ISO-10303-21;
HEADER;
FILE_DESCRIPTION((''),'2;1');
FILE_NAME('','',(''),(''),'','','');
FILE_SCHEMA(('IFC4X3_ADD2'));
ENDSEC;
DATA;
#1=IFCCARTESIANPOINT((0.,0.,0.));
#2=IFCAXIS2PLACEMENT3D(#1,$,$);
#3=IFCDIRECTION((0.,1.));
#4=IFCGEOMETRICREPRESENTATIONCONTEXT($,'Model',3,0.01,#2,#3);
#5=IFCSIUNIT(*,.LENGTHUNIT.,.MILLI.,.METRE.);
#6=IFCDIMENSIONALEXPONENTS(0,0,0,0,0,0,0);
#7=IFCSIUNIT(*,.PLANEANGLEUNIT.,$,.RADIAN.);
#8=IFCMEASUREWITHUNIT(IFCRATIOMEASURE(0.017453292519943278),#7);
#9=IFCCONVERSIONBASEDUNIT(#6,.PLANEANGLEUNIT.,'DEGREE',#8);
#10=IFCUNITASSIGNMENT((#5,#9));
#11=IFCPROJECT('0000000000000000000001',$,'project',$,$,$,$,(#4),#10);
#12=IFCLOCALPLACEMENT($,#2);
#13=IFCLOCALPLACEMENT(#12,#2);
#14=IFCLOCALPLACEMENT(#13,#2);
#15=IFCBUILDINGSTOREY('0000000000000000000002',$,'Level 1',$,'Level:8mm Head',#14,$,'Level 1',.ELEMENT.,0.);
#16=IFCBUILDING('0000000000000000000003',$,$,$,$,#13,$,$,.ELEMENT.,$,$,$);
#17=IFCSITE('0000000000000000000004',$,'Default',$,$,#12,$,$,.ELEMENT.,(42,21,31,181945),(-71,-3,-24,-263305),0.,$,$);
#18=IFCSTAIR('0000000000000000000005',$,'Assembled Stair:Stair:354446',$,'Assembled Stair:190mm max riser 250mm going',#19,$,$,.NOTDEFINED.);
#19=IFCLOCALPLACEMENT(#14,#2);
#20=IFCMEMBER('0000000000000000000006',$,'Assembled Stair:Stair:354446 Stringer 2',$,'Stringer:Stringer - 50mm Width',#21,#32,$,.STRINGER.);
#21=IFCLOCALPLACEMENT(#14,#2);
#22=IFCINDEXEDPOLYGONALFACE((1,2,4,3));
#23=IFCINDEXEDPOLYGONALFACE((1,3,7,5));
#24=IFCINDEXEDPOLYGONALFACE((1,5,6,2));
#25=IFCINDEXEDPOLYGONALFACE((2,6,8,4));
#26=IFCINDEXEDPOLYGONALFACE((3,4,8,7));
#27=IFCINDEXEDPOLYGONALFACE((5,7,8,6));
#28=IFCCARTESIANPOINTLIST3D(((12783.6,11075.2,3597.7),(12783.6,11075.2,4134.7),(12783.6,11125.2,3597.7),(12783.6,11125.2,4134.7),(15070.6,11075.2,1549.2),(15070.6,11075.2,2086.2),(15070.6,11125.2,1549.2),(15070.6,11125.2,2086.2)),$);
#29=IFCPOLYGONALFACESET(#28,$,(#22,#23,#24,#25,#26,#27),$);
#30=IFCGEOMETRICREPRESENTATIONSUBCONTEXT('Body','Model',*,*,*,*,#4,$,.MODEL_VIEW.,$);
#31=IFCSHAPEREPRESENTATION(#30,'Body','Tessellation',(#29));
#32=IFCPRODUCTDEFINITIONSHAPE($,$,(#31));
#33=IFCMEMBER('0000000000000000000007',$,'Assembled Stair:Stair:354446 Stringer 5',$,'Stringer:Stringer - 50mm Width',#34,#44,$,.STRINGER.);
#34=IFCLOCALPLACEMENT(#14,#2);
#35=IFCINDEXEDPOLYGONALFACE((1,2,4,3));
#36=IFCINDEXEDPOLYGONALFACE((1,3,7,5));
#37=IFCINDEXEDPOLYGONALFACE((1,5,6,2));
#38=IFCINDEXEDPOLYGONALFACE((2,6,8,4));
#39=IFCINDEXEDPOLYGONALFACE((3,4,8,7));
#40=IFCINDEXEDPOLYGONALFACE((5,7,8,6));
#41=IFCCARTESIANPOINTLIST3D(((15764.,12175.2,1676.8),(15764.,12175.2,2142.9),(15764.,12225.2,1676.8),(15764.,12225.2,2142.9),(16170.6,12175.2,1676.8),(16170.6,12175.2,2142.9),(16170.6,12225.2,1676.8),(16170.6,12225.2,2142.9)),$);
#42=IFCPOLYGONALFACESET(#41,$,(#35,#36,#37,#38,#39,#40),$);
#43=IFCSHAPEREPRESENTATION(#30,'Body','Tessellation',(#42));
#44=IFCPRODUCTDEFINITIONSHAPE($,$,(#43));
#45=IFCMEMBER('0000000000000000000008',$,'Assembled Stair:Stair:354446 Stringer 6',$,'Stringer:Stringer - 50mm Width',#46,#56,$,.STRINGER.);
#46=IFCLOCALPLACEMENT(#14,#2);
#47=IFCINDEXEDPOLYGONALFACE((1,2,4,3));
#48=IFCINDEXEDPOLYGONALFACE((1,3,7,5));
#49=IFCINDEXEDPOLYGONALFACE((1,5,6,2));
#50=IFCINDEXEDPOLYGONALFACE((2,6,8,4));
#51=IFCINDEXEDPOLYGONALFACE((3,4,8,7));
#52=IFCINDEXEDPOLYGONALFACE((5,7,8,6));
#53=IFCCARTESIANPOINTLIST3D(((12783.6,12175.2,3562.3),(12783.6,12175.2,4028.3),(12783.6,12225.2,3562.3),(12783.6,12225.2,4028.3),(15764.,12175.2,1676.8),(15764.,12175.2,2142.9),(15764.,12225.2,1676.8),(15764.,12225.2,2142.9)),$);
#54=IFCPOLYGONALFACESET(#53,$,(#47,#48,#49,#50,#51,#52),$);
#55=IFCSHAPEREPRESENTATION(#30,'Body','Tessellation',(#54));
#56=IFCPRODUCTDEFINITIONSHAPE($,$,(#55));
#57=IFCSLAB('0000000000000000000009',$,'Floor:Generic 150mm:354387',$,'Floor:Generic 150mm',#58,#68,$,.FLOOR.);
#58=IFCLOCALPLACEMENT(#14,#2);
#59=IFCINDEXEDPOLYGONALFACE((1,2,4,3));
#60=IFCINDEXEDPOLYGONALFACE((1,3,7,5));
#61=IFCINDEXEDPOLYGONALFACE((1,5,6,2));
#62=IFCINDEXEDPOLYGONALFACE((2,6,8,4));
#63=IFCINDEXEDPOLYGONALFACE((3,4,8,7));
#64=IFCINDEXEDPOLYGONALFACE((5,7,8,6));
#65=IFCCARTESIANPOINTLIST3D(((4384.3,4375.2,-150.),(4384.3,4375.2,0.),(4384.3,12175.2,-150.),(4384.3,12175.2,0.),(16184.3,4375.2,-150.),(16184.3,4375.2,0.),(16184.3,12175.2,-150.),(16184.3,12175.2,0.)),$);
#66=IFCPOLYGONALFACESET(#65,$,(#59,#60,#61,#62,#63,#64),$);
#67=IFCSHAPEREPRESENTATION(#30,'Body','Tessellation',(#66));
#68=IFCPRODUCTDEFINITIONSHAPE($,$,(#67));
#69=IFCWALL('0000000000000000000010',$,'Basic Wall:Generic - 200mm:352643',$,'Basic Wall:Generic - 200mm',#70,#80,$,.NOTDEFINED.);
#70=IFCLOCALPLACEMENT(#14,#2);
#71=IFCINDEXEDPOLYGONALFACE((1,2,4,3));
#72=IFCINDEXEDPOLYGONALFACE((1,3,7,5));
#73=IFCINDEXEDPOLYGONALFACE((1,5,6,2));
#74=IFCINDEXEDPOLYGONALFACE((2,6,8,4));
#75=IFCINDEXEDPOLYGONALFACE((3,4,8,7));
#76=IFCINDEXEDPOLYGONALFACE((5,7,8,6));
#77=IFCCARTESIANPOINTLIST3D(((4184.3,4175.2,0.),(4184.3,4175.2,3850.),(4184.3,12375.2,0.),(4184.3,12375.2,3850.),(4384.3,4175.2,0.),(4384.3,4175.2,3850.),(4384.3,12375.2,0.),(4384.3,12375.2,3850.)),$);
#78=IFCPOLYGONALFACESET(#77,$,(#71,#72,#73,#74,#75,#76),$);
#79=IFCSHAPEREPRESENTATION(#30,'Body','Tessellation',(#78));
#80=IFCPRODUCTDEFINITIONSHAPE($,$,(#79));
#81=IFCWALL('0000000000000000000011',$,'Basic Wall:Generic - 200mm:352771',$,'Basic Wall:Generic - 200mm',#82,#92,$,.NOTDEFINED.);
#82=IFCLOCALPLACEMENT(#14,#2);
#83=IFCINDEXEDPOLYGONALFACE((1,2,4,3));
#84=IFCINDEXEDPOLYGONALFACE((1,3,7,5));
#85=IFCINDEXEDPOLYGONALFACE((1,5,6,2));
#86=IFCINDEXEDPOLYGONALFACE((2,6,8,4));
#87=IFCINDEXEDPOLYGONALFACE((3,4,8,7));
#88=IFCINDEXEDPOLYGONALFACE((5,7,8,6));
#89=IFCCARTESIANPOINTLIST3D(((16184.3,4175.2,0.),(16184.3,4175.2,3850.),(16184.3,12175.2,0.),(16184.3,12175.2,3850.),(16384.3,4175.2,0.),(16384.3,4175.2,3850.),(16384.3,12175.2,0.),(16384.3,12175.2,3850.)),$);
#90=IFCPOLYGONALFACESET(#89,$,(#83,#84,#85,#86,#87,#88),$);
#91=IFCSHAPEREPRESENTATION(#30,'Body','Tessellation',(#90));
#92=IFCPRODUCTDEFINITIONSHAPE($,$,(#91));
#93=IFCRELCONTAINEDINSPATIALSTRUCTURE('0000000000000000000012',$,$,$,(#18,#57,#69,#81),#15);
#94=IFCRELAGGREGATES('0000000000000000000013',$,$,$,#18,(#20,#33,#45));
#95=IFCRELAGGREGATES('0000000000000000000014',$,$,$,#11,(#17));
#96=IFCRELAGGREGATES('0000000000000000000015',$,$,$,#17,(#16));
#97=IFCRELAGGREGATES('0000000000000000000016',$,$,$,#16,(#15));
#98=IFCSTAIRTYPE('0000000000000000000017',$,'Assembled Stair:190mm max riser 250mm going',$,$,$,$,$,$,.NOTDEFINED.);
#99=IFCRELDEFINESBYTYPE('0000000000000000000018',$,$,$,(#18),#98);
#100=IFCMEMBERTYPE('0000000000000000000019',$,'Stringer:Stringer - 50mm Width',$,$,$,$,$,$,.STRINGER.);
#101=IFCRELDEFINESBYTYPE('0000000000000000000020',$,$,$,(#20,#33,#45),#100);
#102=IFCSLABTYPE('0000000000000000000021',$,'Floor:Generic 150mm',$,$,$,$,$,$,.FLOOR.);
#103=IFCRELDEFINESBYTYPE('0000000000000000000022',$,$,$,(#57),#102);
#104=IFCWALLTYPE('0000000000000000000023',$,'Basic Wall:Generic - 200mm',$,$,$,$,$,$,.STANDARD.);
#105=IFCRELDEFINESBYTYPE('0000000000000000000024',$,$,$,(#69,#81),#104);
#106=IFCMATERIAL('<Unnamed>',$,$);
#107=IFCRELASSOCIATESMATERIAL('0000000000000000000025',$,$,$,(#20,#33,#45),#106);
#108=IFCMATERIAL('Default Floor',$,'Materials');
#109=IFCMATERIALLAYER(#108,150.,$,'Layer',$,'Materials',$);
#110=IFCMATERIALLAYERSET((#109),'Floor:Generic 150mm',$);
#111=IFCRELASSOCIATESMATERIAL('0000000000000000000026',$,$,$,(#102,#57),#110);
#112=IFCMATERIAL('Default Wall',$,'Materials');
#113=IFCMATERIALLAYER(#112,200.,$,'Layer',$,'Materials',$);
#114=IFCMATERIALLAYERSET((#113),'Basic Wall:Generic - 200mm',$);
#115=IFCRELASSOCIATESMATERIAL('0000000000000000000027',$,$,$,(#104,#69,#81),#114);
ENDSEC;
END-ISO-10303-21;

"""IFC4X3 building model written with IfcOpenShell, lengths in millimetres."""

from ifc_helpers import new_model, entity, si_unit, converted_unit, direction, frame, frame_2d, origin, place, context, subcontext, project, spatial, polyline, rectangle, outline, extrude, clip, bounded_halfspace, material, layer, layer_set, layer_usage, type_object, element, aggregate, save


model = new_model("IFC4X3")

# Units and contexts
model_context = context("Model", 3, precision=0.01, world=origin(), true_north=direction((0.0, 1.0)))
body_context = subcontext(model_context, "Body", "Model", "MODEL_VIEW")
ifc_project = project(units=[si_unit("LENGTHUNIT", "METRE", prefix="MILLI"), converted_unit("PLANEANGLEUNIT", "DEGREE", entity("IfcRatioMeasure", 0.017453292519943278), si_unit("PLANEANGLEUNIT", "RADIAN"), dimensions=[0, 0, 0, 0, 0, 0, 0])], contexts=[model_context])

# Site, building, storey
site_placement = place(None, origin())
site = spatial("IfcSite", under=ifc_project, at=site_placement, Name="Default", CompositionType="ELEMENT", RefLatitude=(42, 21, 31, 181945), RefLongitude=(-71, -3, -24, -263305), RefElevation=0.0)
building_placement = place(site_placement, origin())
building = spatial("IfcBuilding", under=site, at=building_placement, CompositionType="ELEMENT")
storey_placement = place(building_placement, origin())
storey = spatial("IfcBuildingStorey", under=building, at=storey_placement, Name="Level 1", ObjectType="Level:8mm Head", LongName="Level 1", CompositionType="ELEMENT", Elevation=0.0)

# Stair, members
stair_type = type_object("IfcStairType", Name="Assembled Stair:190mm max riser 250mm going", PredefinedType="NOTDEFINED")
stair_placement = place(storey_placement, origin())
stair = element("IfcStair", 1, at=stair_placement, inside=storey, type_object=stair_type, Name="Assembled Stair:Stair:354446", ObjectType="Assembled Stair:190mm max riser 250mm going", PredefinedType="NOTDEFINED")
ifc_material_1 = material(Name="<Unnamed>")
member_type = type_object("IfcMemberType", Name="Stringer:Stringer - 50mm Width", PredefinedType="STRINGER")
member_1_placement = place(stair_placement, frame((12783.6, 11075.2, 1549.2)))
member_1 = element("IfcMember", 2, at=member_1_placement, type_object=member_type, material=ifc_material_1, Name="Assembled Stair:Stair:354446 Stringer 2", ObjectType="Stringer:Stringer - 50mm Width", PredefinedType="STRINGER", context=body_context, shape_type="SweptSolid", body=[
    extrude(outline(polyline([(-1714.3, -200.0), (1356.0, -200.0), (1714.3, 200.0), (-1356.0, 200.0), (-1714.3, -200.0)])), frame((1143.5, 0.0, 1292.8), z_axis=(0.0, 1.0, 0.0), x_axis=(-0.744871, 0.0, 0.667208)), (0.0, 0.0, 1.0), 50.0),
])
member_2_placement = place(stair_placement, frame((15764.0, 12175.2, 1676.8)))
member_2 = element("IfcMember", 3, at=member_2_placement, type_object=member_type, material=ifc_material_1, Name="Assembled Stair:Stair:354446 Stringer 5", ObjectType="Stringer:Stringer - 50mm Width", PredefinedType="STRINGER", context=body_context, shape_type="SweptSolid", body=[
    extrude(rectangle(XDim=406.6, YDim=50.0, at=frame_2d((0.0, 0.0), x_axis=(1.0, 0.0))), frame((203.3, 25.0, 0.0), z_axis=(0.0, 0.0, 1.0), x_axis=(-1.0, 0.0, 0.0)), (0.0, 0.0, 1.0), 466.1),
])
member_3_placement = place(stair_placement, frame((12783.6, 12175.2, 1676.8)))
member_3 = element("IfcMember", 4, at=member_3_placement, type_object=member_type, material=ifc_material_1, Name="Assembled Stair:Stair:354446 Stringer 6", ObjectType="Stringer:Stringer - 50mm Width", PredefinedType="STRINGER", context=body_context, shape_type="SweptSolid", body=[
    extrude(outline(polyline([(-1887.9, -196.9), (1638.7, -196.9), (1887.9, 196.9), (-1638.7, 196.9), (-1887.9, -196.9)])), frame((1490.2, 0.0, 1175.8), z_axis=(0.0, 1.0, 0.0), x_axis=(-0.845092, 0.0, 0.53462)), (0.0, 0.0, 1.0), 50.0),
])

# Slab
ifc_material_2 = material(Name="Default Floor", Category="Materials")
ifc_layer_1 = layer(ifc_material_2, 150.0, Name="Layer", Category="Materials")
ifc_layer_set_1 = layer_set([ifc_layer_1], Name="Floor:Generic 150mm")
ifc_layer_usage = layer_usage(ifc_layer_set_1, "AXIS3", "POSITIVE", 0.0)
slab_type = type_object("IfcSlabType", Name="Floor:Generic 150mm", PredefinedType="FLOOR", material=ifc_layer_set_1)
slab_placement = place(storey_placement, origin())
element("IfcSlab", 5, at=slab_placement, inside=storey, type_object=slab_type, material=ifc_layer_usage, Name="Floor:Generic 150mm:354387", ObjectType="Floor:Generic 150mm", PredefinedType="FLOOR", context=body_context, shape_type="SweptSolid", body=[
    extrude(rectangle(XDim=7800.0, YDim=11800.0, at=frame_2d((0.0, 0.0), x_axis=(1.0, 0.0))), frame((10284.3, 8275.2, 0.0), z_axis=(0.0, 0.0, -1.0), x_axis=(0.0, 1.0, 0.0)), (0.0, 0.0, 1.0), 150.0),
])

# Walls
ifc_material_3 = material(Name="Default Wall", Category="Materials")
ifc_layer_2 = layer(ifc_material_3, 200.0, Name="Layer", Category="Materials")
ifc_layer_set_2 = layer_set([ifc_layer_2], Name="Basic Wall:Generic - 200mm")
wall_type = type_object("IfcWallType", Name="Basic Wall:Generic - 200mm", PredefinedType="STANDARD", material=ifc_layer_set_2)
wall_1_placement = place(storey_placement, frame((4284.3, 4175.2, 0.0), z_axis=(0.0, 0.0, 1.0), x_axis=(0.0, 1.0, 0.0)))
element("IfcWall", 6, at=wall_1_placement, inside=storey, type_object=wall_type, material=ifc_layer_set_2, Name="Basic Wall:Generic - 200mm:352643", ObjectType="Basic Wall:Generic - 200mm", PredefinedType="NOTDEFINED", context=body_context, shape_type="Clipping", body=[
    clip(extrude(rectangle(XDim=8200.0, YDim=200.0, at=frame_2d((4100.0, 0.0), x_axis=(-1.0, 0.0))), origin(), (0.0, 0.0, 1.0), 3850.0), bounded_halfspace(frame((0.0, -100.0, 3850.0), z_axis=(0.0, 0.0, -1.0), x_axis=(0.0, -1.0, 0.0)), True, frame((0.0, -100.0, 3850.0)), polyline([(0.0, 0.0), (200.0, 0.0), (5200.0, 0.0), (5400.0, 0.0), (8000.0, 0.0), (8200.0, 0.0), (8200.0, 200.0), (0.0, 200.0), (0.0, 0.0)]))),
])
wall_2_placement = place(storey_placement, frame((16284.3, 12175.2, 0.0), z_axis=(0.0, 0.0, 1.0), x_axis=(0.0, -1.0, 0.0)))
element("IfcWall", 7, at=wall_2_placement, inside=storey, type_object=wall_type, material=ifc_layer_set_2, Name="Basic Wall:Generic - 200mm:352771", ObjectType="Basic Wall:Generic - 200mm", PredefinedType="NOTDEFINED", context=body_context, shape_type="Clipping", body=[
    clip(extrude(rectangle(XDim=8000.0, YDim=200.0, at=frame_2d((4000.0, 0.0), x_axis=(-1.0, 0.0))), origin(), (0.0, 0.0, 1.0), 3850.0), bounded_halfspace(frame((0.0, -100.0, 3850.0), z_axis=(0.0, 0.0, -1.0), x_axis=(0.0, 1.0, 0.0)), True, frame((0.0, -100.0, 3850.0)), polyline([(0.0, 0.0), (2700.0, 0.0), (4300.0, 0.0), (4500.0, 0.0), (7800.0, 0.0), (8000.0, 0.0), (8000.0, 200.0), (0.0, 200.0), (0.0, 0.0)]))),
])

aggregate(stair, [member_1, member_2, member_3])

save(model, "model.ifc")
